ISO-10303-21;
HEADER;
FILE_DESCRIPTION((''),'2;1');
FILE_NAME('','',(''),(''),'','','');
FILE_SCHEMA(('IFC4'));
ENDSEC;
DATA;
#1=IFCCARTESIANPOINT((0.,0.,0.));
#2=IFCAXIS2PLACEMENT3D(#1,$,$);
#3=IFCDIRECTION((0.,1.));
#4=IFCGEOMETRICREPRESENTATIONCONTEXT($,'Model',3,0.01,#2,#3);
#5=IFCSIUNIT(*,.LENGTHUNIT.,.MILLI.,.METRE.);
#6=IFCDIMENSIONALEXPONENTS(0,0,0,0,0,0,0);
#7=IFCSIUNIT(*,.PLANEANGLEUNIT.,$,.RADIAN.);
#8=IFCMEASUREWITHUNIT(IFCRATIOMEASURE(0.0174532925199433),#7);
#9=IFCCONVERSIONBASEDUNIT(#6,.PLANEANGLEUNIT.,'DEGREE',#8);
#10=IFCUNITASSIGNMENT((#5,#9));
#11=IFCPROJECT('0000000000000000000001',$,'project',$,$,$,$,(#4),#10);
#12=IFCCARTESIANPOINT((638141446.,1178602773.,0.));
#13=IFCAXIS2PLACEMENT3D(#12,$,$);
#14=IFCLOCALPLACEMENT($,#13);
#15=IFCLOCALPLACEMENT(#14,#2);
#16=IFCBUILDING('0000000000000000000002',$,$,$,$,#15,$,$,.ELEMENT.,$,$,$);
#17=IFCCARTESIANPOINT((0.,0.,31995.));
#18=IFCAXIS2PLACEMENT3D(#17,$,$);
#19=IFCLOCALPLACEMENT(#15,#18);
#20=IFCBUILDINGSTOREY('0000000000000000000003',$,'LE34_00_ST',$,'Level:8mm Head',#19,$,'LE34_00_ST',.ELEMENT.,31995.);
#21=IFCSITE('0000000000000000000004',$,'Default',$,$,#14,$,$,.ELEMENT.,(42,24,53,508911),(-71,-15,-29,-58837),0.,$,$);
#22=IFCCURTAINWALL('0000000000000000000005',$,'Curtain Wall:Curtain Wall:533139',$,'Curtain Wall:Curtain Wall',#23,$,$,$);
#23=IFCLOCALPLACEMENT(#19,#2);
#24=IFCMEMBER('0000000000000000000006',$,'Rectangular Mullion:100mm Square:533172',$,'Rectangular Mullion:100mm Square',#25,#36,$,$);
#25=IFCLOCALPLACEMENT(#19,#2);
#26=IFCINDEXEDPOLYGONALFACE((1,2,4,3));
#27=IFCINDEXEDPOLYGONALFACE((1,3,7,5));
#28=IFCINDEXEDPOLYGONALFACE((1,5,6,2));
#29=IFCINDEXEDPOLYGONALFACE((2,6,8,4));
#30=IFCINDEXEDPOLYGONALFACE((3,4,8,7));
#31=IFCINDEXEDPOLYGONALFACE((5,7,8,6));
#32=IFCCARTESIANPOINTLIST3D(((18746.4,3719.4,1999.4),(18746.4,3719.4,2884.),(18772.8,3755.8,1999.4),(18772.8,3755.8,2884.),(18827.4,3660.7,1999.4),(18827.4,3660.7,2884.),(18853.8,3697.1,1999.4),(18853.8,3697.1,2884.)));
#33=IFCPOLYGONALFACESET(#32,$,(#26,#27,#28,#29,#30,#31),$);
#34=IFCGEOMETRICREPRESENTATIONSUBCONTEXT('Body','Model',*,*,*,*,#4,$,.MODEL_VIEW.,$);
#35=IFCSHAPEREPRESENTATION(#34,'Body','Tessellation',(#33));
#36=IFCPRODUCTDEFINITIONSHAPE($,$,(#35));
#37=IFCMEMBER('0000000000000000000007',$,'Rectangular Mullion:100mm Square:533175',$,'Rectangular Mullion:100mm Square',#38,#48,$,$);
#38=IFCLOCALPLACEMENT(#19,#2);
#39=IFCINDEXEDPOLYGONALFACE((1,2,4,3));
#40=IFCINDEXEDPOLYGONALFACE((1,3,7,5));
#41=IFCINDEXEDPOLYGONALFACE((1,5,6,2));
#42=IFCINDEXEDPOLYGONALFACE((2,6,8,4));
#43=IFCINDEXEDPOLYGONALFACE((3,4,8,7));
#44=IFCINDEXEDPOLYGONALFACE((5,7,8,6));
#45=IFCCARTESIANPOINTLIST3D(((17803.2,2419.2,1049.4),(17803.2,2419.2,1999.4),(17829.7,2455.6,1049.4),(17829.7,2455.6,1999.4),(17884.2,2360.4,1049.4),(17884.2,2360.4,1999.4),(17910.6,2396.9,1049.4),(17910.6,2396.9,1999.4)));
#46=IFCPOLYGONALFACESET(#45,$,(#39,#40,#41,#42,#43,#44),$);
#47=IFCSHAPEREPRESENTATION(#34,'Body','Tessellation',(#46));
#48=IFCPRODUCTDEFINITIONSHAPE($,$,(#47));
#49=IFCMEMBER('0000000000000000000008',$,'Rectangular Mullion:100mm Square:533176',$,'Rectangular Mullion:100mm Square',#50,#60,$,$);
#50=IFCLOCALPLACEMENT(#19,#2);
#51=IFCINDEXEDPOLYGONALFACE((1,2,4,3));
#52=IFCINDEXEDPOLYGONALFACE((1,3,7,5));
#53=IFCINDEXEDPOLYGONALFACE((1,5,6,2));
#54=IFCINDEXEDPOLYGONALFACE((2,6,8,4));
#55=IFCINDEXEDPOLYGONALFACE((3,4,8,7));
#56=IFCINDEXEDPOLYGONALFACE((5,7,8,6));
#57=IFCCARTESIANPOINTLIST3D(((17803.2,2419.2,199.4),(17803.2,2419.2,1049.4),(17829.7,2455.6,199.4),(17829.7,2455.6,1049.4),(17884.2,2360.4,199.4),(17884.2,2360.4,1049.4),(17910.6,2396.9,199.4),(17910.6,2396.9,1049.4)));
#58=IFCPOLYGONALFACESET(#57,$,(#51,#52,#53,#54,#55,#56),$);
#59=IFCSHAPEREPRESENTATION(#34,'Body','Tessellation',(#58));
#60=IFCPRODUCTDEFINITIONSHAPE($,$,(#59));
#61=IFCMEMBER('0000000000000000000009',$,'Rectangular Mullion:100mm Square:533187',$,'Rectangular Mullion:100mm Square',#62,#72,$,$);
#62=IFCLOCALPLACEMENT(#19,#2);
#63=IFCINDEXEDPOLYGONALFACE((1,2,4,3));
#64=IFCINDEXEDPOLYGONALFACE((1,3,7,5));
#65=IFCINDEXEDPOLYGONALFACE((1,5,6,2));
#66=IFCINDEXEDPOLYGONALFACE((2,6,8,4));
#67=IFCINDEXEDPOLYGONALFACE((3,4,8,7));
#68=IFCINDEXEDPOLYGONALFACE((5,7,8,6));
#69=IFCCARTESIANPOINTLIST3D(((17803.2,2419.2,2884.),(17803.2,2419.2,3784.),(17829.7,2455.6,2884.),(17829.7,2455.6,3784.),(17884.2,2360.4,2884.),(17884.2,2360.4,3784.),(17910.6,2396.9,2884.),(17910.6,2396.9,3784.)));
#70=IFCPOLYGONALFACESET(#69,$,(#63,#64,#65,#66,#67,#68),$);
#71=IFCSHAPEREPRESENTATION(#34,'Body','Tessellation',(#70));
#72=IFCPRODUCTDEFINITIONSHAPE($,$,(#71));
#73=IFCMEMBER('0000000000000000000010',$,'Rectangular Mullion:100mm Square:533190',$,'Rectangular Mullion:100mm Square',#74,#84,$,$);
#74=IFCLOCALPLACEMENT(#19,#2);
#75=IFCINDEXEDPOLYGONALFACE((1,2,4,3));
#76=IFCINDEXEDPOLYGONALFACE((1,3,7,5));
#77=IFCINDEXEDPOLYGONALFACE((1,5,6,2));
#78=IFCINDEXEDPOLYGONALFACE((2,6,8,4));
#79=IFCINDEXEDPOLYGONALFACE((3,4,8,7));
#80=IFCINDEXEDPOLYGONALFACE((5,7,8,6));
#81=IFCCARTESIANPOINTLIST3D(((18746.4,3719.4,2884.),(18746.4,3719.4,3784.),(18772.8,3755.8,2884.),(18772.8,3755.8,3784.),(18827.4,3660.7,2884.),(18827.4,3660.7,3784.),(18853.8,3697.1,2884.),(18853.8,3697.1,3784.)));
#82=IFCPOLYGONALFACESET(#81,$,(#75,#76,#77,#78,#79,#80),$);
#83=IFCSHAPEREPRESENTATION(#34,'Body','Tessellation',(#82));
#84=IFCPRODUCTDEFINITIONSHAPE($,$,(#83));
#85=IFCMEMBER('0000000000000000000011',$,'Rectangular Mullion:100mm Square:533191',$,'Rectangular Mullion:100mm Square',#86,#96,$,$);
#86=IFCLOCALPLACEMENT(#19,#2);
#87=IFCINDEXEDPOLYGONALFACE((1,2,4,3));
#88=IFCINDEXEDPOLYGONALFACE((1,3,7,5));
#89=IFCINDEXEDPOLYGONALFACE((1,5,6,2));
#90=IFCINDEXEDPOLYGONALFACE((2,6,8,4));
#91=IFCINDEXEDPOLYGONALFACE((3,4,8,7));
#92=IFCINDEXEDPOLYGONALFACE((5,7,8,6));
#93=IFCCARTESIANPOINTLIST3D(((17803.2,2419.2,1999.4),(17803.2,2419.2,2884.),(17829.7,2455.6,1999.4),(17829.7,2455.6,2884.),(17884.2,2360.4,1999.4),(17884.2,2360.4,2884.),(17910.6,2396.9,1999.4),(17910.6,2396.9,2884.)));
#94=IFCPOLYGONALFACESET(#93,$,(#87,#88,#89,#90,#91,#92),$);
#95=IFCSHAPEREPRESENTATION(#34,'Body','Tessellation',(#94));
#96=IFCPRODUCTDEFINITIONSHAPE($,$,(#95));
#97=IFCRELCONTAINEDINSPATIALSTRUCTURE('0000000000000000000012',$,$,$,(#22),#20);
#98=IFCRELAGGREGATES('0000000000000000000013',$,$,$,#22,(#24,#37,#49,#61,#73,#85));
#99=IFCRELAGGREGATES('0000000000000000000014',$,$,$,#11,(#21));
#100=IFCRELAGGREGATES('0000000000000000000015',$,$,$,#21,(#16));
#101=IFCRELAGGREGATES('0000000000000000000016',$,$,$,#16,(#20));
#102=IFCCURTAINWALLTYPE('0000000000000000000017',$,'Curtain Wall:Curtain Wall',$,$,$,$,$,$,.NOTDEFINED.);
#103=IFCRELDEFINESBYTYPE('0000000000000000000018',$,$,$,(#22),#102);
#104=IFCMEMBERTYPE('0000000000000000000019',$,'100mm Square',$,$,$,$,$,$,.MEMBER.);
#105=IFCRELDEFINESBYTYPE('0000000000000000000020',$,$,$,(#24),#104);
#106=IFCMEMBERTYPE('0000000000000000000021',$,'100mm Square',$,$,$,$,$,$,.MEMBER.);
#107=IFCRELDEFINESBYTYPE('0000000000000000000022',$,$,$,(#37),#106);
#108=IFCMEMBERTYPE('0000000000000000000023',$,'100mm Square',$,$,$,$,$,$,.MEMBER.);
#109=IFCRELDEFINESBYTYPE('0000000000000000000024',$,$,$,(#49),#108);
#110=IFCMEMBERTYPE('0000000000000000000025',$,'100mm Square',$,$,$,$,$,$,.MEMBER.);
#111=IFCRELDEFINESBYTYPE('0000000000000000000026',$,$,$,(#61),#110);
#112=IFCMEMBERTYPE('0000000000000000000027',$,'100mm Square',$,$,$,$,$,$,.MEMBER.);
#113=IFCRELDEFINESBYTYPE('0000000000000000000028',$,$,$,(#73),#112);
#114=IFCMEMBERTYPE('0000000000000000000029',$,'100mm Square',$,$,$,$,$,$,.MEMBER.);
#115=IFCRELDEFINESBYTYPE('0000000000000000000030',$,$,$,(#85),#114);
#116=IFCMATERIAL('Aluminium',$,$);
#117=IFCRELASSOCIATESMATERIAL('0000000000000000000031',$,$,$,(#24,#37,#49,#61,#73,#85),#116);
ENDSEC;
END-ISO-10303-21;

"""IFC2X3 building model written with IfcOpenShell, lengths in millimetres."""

from ifc_helpers import new_model, entity, si_unit, converted_unit, direction, frame, origin, origin_2d_with_axis, place, context, subcontext, project, spatial, rectangle, extrude, source, transform, mapped, material, type_object, type_shapes, element, aggregate, save


model = new_model("IFC2X3")

# Units and contexts
model_context = context("Model", 3, precision=0.01, world=origin(), true_north=direction((0.0, 1.0)))
body_context = subcontext(model_context, "Body", "Model", "MODEL_VIEW")
ifc_project = project(units=[si_unit("LENGTHUNIT", "METRE", prefix="MILLI"), converted_unit("PLANEANGLEUNIT", "DEGREE", entity("IfcRatioMeasure", 0.0174532925199433), si_unit("PLANEANGLEUNIT", "RADIAN"), dimensions=[0, 0, 0, 0, 0, 0, 0])], contexts=[model_context])

# Site, building, storey
site_placement = place(None, frame((638141446.0, 1178602773.0, 0.0)))
site = spatial("IfcSite", under=ifc_project, at=site_placement, Name="Default", CompositionType="ELEMENT", RefLatitude=(42, 24, 53, 508911), RefLongitude=(-71, -15, -29, -58837), RefElevation=0.0)
building_placement = place(site_placement, origin())
building = spatial("IfcBuilding", under=site, at=building_placement, CompositionType="ELEMENT")
storey_placement = place(building_placement, frame((0.0, 0.0, 31995.0)))
storey = spatial("IfcBuildingStorey", under=building, at=storey_placement, Name="LE34_00_ST", ObjectType="Level:8mm Head", LongName="LE34_00_ST", CompositionType="ELEMENT", Elevation=31995.0)

# Curtain wall, members
curtain_wall_type = type_object("IfcCurtainWallType", Name="Curtain Wall:Curtain Wall", PredefinedType="NOTDEFINED")
ifc_material_1 = material(Name="Aluminium")
curtain_wall_1_placement = place(storey_placement, frame((0.0, 0.0, -31995.0)))
curtain_wall_1 = element("IfcCurtainWall", 1, at=curtain_wall_1_placement, inside=storey, type_object=curtain_wall_type, Name="Curtain Wall:Curtain Wall:533139", ObjectType="Curtain Wall:Curtain Wall")
member_type_1 = type_object("IfcMemberType", Name="100mm Square", PredefinedType="MEMBER")
shared_shape_1 = source(origin(), body_context, "Body", "SweptSolid", [
    extrude(rectangle(XDim=100.0, YDim=45.0, at=origin_2d_with_axis()), frame((-22.5, 0.0, -884.6), z_axis=(0.0, 0.0, 1.0), x_axis=(0.0, -1.0, 0.0)), (0.0, 0.0, 1.0), 884.6),
])
type_shapes(member_type_1, [shared_shape_1])
member_1_placement = place(storey_placement, frame((18813.3, 3726.5, 1999.4), z_axis=(0.0, 0.0, -1.0), x_axis=(0.587164, 0.809468, 0.0)))
member_1 = element("IfcMember", 2, at=member_1_placement, type_object=member_type_1, material=ifc_material_1, Name="Rectangular Mullion:100mm Square:533172", ObjectType="Rectangular Mullion:100mm Square", context=body_context, shape_type="MappedRepresentation", body=[
    mapped(shared_shape_1, transform((0.0, 0.0, 0.0), scale=1.0)),
])
member_type_2 = type_object("IfcMemberType", Name="100mm Square", PredefinedType="MEMBER")
shared_shape_2 = source(origin(), body_context, "Body", "SweptSolid", [
    extrude(rectangle(XDim=100.0, YDim=45.0, at=origin_2d_with_axis()), frame((-22.5, 0.0, -950.0), z_axis=(0.0, 0.0, 1.0), x_axis=(0.0, -1.0, 0.0)), (0.0, 0.0, 1.0), 950.0),
])
type_shapes(member_type_2, [shared_shape_2])
member_2_placement = place(storey_placement, frame((17843.7, 2389.8, 1999.4), z_axis=(0.0, 0.0, 1.0), x_axis=(-0.587164, -0.809468, 0.0)))
member_2 = element("IfcMember", 3, at=member_2_placement, type_object=member_type_2, material=ifc_material_1, Name="Rectangular Mullion:100mm Square:533175", ObjectType="Rectangular Mullion:100mm Square", context=body_context, shape_type="MappedRepresentation", body=[
    mapped(shared_shape_2, transform((0.0, 0.0, 0.0), scale=1.0)),
])
member_type_3 = type_object("IfcMemberType", Name="100mm Square", PredefinedType="MEMBER")
shared_shape_3 = source(origin(), body_context, "Body", "SweptSolid", [
    extrude(rectangle(XDim=100.0, YDim=45.0, at=origin_2d_with_axis()), frame((-22.5, 0.0, -850.0), z_axis=(0.0, 0.0, 1.0), x_axis=(0.0, -1.0, 0.0)), (0.0, 0.0, 1.0), 850.0),
])
type_shapes(member_type_3, [shared_shape_3])
member_3_placement = place(storey_placement, frame((17843.7, 2389.8, 1049.4), z_axis=(0.0, 0.0, 1.0), x_axis=(-0.587164, -0.809468, 0.0)))
member_3 = element("IfcMember", 4, at=member_3_placement, type_object=member_type_3, material=ifc_material_1, Name="Rectangular Mullion:100mm Square:533176", ObjectType="Rectangular Mullion:100mm Square", context=body_context, shape_type="MappedRepresentation", body=[
    mapped(shared_shape_3, transform((0.0, 0.0, 0.0), scale=1.0)),
])
member_type_4 = type_object("IfcMemberType", Name="100mm Square", PredefinedType="MEMBER")
shared_shape_4 = source(origin(), body_context, "Body", "SweptSolid", [
    extrude(rectangle(XDim=100.0, YDim=45.0, at=origin_2d_with_axis()), frame((-22.5, 0.0, -900.0), z_axis=(0.0, 0.0, 1.0), x_axis=(0.0, -1.0, 0.0)), (0.0, 0.0, 1.0), 900.0),
])
type_shapes(member_type_4, [shared_shape_4])
member_4_placement = place(storey_placement, frame((17843.7, 2389.8, 3784.0), z_axis=(0.0, 0.0, 1.0), x_axis=(-0.587164, -0.809468, 0.0)))
member_4 = element("IfcMember", 5, at=member_4_placement, type_object=member_type_4, material=ifc_material_1, Name="Rectangular Mullion:100mm Square:533187", ObjectType="Rectangular Mullion:100mm Square", context=body_context, shape_type="MappedRepresentation", body=[
    mapped(shared_shape_4, transform((0.0, 0.0, 0.0), scale=1.0)),
])
member_type_5 = type_object("IfcMemberType", Name="100mm Square", PredefinedType="MEMBER")
shared_shape_5 = source(origin(), body_context, "Body", "SweptSolid", [
    extrude(rectangle(XDim=100.0, YDim=45.0, at=origin_2d_with_axis()), frame((-22.5, 0.0, -900.0), z_axis=(0.0, 0.0, 1.0), x_axis=(0.0, -1.0, 0.0)), (0.0, 0.0, 1.0), 900.0),
])
type_shapes(member_type_5, [shared_shape_5])
member_5_placement = place(storey_placement, frame((18813.3, 3726.5, 2884.0), z_axis=(0.0, 0.0, -1.0), x_axis=(0.587164, 0.809468, 0.0)))
member_5 = element("IfcMember", 6, at=member_5_placement, type_object=member_type_5, material=ifc_material_1, Name="Rectangular Mullion:100mm Square:533190", ObjectType="Rectangular Mullion:100mm Square", context=body_context, shape_type="MappedRepresentation", body=[
    mapped(shared_shape_5, transform((0.0, 0.0, 0.0), scale=1.0)),
])
member_type_6 = type_object("IfcMemberType", Name="100mm Square", PredefinedType="MEMBER")
shared_shape_6 = source(origin(), body_context, "Body", "SweptSolid", [
    extrude(rectangle(XDim=100.0, YDim=45.0, at=origin_2d_with_axis()), frame((-22.5, 0.0, -884.6), z_axis=(0.0, 0.0, 1.0), x_axis=(0.0, -1.0, 0.0)), (0.0, 0.0, 1.0), 884.6),
])
type_shapes(member_type_6, [shared_shape_6])
member_6_placement = place(storey_placement, frame((17843.7, 2389.8, 2884.0), z_axis=(0.0, 0.0, 1.0), x_axis=(-0.587164, -0.809468, 0.0)))
member_6 = element("IfcMember", 7, at=member_6_placement, type_object=member_type_6, material=ifc_material_1, Name="Rectangular Mullion:100mm Square:533191", ObjectType="Rectangular Mullion:100mm Square", context=body_context, shape_type="MappedRepresentation", body=[
    mapped(shared_shape_6, transform((0.0, 0.0, 0.0), scale=1.0)),
])

aggregate(curtain_wall_1, [member_1, member_2, member_3, member_4, member_5, member_6])

save(model, "model.ifc")
